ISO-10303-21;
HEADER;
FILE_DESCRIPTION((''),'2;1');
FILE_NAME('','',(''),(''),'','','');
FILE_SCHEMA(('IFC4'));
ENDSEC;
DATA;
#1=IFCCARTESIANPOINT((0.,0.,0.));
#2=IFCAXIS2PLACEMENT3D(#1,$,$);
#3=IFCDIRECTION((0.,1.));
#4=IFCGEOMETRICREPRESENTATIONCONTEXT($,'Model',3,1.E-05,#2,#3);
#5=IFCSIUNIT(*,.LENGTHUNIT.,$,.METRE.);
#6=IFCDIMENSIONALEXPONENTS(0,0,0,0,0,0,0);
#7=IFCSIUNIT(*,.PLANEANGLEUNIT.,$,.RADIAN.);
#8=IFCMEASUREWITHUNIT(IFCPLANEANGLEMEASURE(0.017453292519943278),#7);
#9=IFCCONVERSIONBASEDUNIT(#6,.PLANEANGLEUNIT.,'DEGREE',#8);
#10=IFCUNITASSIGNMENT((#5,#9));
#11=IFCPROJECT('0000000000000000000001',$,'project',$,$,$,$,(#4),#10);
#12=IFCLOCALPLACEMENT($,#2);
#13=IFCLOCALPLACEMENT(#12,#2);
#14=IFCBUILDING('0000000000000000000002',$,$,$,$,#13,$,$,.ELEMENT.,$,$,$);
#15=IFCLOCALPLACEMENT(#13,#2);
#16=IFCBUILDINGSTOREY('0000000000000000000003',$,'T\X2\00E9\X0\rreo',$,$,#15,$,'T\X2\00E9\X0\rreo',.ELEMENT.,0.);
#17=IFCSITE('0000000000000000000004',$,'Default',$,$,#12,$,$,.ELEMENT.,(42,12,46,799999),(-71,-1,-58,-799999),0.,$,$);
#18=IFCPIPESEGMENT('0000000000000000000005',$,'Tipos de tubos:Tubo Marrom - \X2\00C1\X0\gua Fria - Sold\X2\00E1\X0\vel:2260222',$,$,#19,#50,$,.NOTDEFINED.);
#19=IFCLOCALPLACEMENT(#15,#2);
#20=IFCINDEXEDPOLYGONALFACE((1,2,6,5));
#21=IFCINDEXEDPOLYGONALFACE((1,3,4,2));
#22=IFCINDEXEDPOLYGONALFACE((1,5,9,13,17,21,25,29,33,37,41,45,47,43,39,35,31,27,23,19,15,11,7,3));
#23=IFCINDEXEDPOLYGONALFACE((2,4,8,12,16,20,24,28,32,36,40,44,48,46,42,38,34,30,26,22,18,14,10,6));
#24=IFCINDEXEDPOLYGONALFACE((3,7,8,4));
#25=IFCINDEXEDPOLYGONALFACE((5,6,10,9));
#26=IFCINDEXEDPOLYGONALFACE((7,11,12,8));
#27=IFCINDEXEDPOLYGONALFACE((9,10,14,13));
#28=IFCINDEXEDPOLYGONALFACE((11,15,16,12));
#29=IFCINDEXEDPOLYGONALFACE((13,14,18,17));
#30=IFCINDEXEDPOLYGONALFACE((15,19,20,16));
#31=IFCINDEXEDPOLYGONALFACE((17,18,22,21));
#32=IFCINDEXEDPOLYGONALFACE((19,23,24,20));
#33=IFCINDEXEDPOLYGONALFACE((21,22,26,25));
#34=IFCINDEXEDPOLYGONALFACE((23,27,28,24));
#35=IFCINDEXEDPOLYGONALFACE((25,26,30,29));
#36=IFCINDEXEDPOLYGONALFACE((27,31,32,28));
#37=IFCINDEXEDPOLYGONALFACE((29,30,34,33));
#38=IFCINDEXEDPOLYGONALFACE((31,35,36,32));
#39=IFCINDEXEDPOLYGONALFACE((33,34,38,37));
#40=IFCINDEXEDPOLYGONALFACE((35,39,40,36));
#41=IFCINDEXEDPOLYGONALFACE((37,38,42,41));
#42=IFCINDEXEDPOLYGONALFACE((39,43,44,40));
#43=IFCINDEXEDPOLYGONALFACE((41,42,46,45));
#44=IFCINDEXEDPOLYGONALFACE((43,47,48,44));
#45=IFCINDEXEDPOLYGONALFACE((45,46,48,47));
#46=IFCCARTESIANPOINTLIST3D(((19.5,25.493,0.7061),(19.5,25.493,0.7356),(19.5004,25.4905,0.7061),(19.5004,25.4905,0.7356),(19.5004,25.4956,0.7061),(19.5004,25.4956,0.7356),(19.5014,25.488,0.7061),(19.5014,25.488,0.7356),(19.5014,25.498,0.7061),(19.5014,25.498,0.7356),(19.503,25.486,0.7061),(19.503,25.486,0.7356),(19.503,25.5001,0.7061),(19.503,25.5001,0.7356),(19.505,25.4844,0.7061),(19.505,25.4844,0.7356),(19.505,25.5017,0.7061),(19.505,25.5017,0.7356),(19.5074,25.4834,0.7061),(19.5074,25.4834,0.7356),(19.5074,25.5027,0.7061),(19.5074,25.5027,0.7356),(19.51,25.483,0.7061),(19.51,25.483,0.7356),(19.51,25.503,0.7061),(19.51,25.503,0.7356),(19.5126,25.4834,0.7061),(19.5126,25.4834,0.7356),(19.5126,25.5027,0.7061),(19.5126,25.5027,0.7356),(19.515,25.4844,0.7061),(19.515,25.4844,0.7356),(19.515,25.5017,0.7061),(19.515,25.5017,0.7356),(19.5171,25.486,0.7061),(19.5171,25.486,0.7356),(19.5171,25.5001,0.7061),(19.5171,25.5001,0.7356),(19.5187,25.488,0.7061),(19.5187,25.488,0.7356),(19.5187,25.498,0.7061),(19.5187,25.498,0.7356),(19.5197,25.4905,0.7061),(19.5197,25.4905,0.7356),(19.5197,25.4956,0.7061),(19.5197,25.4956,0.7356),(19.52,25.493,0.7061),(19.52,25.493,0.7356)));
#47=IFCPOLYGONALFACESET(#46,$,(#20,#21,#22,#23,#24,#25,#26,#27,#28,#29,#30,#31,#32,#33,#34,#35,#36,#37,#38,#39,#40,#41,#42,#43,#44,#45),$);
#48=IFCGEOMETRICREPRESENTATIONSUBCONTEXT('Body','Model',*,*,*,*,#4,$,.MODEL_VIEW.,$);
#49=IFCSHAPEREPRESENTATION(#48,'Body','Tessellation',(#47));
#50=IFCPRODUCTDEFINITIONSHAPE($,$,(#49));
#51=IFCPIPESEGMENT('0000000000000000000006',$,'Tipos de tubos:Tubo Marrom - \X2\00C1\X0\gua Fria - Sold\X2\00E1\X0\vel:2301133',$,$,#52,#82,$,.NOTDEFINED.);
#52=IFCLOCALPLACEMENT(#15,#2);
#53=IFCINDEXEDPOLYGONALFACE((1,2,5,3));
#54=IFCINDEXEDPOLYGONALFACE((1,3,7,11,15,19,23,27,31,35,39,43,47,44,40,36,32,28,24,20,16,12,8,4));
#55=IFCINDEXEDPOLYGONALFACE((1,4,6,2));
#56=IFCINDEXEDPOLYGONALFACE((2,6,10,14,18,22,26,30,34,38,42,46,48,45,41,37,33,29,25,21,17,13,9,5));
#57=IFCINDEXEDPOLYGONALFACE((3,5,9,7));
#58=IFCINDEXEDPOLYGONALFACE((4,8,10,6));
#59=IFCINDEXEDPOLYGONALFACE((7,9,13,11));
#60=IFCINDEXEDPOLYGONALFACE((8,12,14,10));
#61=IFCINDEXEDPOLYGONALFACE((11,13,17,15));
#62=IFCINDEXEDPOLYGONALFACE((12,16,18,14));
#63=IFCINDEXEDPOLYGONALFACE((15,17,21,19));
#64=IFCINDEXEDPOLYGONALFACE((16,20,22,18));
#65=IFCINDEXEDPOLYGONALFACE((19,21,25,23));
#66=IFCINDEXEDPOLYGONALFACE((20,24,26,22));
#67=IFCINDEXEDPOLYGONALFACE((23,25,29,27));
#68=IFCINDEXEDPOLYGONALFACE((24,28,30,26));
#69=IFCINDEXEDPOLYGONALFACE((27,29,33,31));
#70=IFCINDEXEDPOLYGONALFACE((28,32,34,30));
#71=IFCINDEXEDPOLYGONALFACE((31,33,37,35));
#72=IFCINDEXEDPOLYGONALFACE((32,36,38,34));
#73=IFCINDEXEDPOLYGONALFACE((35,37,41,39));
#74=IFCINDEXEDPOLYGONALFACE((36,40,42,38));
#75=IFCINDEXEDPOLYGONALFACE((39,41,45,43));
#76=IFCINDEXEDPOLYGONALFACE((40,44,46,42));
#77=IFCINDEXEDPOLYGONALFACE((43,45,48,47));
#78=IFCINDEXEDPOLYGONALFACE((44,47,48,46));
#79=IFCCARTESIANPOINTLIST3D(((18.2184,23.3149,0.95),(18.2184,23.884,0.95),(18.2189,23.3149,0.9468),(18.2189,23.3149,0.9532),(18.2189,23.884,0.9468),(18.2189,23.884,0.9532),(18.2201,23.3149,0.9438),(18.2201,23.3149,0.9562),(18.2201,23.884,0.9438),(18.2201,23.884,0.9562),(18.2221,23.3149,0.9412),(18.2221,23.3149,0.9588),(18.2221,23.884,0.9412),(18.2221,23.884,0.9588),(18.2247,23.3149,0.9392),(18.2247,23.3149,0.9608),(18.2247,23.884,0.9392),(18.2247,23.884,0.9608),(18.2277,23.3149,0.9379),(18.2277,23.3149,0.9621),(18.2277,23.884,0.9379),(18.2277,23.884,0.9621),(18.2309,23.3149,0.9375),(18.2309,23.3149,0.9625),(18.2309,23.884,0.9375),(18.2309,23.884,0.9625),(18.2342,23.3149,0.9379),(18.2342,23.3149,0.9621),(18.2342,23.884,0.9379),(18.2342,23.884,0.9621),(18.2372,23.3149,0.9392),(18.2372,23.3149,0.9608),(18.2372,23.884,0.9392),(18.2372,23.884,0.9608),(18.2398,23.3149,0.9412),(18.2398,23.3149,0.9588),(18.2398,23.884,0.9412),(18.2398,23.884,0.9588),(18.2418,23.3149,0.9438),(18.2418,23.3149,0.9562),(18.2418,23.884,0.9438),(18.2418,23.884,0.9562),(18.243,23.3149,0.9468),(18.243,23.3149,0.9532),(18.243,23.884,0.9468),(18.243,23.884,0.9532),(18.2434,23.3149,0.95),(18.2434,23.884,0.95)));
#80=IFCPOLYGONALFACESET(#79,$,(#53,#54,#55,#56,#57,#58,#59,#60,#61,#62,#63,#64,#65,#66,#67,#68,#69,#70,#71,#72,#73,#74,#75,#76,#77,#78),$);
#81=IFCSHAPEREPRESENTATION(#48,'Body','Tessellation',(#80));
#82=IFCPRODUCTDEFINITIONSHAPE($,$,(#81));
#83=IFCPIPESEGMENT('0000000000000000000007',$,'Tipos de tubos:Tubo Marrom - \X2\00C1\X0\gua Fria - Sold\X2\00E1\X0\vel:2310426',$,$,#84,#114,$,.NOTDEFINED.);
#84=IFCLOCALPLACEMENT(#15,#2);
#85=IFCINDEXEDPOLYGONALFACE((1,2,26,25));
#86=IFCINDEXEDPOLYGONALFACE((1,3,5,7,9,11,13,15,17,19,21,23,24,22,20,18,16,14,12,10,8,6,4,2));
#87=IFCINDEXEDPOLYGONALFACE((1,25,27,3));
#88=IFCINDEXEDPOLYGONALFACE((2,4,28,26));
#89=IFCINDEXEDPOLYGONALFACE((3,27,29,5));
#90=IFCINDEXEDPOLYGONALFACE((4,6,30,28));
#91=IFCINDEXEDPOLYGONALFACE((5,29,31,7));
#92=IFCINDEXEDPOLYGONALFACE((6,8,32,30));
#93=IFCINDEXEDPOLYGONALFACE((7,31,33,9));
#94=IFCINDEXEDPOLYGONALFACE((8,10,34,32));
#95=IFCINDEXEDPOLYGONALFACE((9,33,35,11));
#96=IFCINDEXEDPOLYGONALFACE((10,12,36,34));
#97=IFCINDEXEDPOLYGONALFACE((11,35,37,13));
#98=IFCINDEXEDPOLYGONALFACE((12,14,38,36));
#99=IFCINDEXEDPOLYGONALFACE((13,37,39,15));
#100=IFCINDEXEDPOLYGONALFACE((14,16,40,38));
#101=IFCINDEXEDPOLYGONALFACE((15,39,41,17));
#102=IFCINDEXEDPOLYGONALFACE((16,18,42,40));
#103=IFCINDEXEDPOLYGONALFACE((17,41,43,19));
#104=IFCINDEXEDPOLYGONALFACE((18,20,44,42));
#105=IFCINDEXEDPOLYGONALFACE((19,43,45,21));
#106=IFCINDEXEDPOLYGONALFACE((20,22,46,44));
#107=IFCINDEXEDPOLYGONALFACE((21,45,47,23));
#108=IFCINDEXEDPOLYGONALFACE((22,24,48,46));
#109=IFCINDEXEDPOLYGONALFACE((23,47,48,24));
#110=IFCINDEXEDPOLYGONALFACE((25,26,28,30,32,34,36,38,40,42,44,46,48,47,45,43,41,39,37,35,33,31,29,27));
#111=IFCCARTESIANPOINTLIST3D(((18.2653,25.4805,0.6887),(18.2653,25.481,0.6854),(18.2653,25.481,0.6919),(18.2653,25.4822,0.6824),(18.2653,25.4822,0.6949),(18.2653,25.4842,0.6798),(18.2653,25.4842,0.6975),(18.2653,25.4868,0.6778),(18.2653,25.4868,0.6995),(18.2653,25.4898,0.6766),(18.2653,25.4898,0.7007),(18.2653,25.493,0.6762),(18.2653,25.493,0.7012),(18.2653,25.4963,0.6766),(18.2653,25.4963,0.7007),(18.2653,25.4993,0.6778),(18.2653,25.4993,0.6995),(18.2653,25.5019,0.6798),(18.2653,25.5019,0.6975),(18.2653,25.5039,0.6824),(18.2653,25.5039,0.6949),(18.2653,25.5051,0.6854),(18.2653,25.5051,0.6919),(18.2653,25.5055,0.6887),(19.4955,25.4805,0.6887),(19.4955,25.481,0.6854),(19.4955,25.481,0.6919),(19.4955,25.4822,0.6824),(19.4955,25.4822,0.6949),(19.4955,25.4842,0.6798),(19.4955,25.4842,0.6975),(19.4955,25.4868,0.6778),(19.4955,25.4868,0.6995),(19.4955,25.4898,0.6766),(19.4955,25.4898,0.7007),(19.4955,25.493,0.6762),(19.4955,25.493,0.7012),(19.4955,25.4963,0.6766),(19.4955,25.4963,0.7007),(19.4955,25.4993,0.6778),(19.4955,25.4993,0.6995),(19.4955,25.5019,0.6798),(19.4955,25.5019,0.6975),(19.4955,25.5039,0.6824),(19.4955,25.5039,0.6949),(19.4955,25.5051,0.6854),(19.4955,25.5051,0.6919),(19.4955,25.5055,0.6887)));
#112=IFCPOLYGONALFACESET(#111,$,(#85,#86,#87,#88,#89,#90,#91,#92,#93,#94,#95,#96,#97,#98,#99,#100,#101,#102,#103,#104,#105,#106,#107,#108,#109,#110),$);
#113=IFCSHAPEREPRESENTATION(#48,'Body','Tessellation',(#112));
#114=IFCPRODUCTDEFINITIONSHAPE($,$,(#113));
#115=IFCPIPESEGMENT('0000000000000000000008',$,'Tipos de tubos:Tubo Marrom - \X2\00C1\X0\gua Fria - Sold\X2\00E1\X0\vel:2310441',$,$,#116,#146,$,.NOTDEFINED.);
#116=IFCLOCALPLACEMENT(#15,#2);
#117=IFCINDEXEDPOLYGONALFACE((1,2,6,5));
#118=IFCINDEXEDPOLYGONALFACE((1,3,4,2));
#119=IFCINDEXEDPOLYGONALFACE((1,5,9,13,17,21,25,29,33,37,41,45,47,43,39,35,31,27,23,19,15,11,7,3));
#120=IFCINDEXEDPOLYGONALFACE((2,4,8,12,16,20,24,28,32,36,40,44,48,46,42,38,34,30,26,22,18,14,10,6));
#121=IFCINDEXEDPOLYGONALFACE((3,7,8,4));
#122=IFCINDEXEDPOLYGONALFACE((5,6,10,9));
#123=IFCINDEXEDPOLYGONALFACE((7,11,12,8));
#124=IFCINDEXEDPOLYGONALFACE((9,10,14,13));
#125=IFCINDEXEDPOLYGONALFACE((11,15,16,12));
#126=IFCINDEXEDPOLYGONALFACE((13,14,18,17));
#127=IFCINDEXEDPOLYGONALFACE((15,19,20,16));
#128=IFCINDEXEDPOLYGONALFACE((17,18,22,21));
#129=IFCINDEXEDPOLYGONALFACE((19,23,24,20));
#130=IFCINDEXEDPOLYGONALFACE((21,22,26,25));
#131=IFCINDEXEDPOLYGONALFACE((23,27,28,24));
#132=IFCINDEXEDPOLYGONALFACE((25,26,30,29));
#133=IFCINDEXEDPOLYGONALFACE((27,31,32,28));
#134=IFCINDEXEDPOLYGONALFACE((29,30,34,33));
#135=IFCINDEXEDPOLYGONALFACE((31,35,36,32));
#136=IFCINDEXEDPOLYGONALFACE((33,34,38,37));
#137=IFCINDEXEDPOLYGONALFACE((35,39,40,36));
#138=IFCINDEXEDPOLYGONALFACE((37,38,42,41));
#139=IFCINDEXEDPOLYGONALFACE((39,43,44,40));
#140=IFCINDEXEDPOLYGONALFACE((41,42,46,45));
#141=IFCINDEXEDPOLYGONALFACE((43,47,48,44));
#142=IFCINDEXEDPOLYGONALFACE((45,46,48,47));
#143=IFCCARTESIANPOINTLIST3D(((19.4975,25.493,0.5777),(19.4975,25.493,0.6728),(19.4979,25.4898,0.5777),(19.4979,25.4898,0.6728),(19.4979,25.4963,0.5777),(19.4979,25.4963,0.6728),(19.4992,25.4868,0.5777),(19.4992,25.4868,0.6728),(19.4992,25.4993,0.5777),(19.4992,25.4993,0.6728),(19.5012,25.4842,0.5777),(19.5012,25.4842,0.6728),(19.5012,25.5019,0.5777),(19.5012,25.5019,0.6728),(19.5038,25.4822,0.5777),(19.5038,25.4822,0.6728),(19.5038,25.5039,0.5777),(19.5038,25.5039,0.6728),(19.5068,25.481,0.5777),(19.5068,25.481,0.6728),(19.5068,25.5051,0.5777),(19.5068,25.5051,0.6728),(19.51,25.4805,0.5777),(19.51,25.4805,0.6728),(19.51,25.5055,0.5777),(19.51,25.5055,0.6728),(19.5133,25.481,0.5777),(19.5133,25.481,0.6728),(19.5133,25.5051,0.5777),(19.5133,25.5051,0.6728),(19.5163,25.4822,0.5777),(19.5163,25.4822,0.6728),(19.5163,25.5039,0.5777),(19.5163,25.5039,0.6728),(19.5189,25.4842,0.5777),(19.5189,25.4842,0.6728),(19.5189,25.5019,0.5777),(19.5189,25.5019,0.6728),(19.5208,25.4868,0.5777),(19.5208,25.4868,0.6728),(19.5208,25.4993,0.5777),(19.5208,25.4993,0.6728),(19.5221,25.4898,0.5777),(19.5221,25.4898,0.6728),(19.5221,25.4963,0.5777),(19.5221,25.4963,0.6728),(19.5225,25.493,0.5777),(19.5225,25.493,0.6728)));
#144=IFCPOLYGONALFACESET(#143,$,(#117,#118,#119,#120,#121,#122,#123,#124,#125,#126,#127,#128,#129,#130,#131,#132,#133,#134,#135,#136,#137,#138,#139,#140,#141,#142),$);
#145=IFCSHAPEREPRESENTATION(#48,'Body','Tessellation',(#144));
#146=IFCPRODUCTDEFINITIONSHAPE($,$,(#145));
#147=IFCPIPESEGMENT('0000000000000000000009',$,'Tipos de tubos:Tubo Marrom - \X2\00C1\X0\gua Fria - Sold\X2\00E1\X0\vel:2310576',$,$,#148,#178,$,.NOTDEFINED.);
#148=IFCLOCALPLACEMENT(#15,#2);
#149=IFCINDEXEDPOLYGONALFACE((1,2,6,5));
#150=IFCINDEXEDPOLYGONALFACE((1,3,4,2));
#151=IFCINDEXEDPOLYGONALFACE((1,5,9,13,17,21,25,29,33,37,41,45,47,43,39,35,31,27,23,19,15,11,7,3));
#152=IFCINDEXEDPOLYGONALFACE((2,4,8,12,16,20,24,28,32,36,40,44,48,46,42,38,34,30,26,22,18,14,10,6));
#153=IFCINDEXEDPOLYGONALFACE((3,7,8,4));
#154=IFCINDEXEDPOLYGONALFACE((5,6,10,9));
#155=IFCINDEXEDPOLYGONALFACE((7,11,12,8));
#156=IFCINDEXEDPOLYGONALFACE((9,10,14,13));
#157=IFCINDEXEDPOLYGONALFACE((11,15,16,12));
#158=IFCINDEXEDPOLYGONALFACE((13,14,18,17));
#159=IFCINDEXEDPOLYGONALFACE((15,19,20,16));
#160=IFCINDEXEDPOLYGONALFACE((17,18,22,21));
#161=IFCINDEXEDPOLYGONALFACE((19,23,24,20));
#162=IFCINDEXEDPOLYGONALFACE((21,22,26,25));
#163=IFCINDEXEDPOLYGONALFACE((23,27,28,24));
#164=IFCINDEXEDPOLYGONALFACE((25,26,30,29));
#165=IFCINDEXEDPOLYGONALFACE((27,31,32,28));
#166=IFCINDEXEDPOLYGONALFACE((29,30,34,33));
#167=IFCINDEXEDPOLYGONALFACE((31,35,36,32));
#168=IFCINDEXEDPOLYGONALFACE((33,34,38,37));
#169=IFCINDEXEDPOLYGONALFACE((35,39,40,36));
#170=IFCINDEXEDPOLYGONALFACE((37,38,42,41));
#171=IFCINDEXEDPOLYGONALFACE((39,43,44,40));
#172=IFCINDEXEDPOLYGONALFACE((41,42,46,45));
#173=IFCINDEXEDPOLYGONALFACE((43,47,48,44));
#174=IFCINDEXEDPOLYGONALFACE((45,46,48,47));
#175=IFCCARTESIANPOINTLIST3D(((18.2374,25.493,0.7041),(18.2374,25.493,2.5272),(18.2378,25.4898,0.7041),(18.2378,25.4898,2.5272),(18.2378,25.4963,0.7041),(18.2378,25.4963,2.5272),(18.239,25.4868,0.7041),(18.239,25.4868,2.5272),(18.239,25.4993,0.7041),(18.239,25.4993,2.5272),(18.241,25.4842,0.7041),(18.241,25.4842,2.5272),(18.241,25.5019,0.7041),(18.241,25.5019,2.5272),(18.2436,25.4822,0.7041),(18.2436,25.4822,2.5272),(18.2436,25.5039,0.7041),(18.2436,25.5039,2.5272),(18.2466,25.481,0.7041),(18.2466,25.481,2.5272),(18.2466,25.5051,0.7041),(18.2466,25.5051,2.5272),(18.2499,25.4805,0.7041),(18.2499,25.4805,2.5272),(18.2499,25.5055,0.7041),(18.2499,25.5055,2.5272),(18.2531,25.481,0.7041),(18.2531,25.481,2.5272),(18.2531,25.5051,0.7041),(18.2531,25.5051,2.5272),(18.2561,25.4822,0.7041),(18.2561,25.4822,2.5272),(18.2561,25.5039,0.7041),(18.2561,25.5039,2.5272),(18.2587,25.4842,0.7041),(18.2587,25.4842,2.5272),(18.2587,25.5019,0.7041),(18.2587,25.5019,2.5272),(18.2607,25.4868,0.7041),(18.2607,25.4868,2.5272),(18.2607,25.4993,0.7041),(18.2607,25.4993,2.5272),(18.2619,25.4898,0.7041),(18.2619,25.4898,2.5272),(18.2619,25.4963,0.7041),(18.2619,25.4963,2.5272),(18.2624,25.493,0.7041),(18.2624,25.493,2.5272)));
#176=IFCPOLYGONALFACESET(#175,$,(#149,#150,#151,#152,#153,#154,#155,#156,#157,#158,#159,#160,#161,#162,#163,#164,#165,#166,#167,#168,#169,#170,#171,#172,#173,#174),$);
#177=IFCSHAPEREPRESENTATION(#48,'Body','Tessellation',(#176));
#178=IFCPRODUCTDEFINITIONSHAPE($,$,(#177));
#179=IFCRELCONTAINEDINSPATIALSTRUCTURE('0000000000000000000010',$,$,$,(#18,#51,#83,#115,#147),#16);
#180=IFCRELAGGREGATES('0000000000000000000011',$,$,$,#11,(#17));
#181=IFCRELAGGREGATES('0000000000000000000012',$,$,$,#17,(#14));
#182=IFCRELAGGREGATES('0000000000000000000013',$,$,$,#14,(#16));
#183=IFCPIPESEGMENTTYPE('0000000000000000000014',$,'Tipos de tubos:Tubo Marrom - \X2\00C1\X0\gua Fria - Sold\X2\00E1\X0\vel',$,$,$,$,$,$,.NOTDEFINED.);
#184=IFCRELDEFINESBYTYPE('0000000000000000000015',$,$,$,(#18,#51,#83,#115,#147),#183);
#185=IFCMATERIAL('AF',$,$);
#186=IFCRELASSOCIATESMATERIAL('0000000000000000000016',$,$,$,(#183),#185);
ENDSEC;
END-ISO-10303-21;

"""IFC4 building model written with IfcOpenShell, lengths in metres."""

from ifc_helpers import new_model, entity, si_unit, converted_unit, direction, frame, origin, place, context, subcontext, project, spatial, arc, indexed_curve, outline, extrude, material, type_object, element, save


model = new_model("IFC4")

# Units and contexts
model_context = context("Model", 3, precision=1e-05, world=origin(), true_north=direction((0.0, 1.0)))
body_context = subcontext(model_context, "Body", "Model", "MODEL_VIEW")
ifc_project = project(units=[si_unit("LENGTHUNIT", "METRE"), converted_unit("PLANEANGLEUNIT", "DEGREE", entity("IfcPlaneAngleMeasure", 0.017453292519943278), si_unit("PLANEANGLEUNIT", "RADIAN"), dimensions=[0, 0, 0, 0, 0, 0, 0])], contexts=[model_context])

# Site, building, storey
site_placement = place(None, origin())
site = spatial("IfcSite", under=ifc_project, at=site_placement, Name="Default", CompositionType="ELEMENT", RefLatitude=(42, 12, 46, 799999), RefLongitude=(-71, -1, -58, -799999), RefElevation=0.0)
building_placement = place(site_placement, origin())
building = spatial("IfcBuilding", under=site, at=building_placement, CompositionType="ELEMENT")
storey_placement = place(building_placement, origin())
storey = spatial("IfcBuildingStorey", under=building, at=storey_placement, Name="Térreo", LongName="Térreo", CompositionType="ELEMENT", Elevation=0.0)

# Pipe segments
ifc_material_1 = material(Name="AF")
pipe_segment_type_1 = type_object("IfcPipeSegmentType", Name="Tipos de tubos:Tubo Marrom - Água Fria - Soldável", PredefinedType="NOTDEFINED", material=ifc_material_1)
pipe_segment_1_placement = place(storey_placement, origin())
element("IfcPipeSegment", 1, at=pipe_segment_1_placement, inside=storey, type_object=pipe_segment_type_1, Name="Tipos de tubos:Tubo Marrom - Água Fria - Soldável:2260222", PredefinedType="NOTDEFINED", context=body_context, shape_type="SweptSolid", body=[
    extrude(outline(indexed_curve([(0.01, 0.0), (0.0071, 0.0071), (0.0, 0.01), (-0.0071, 0.0071), (-0.01, 0.0), (-0.0071, -0.0071), (0.0, -0.01), (0.0071, -0.0071)], segments=[arc(1, 2, 3), arc(3, 4, 5), arc(5, 6, 7), arc(7, 8, 1)], self_intersect=False)), frame((19.51, 25.493, 0.7061), z_axis=(0.0, 0.0, 1.0), x_axis=(-1.0, 0.0, 0.0)), (0.0, 0.0, 1.0), 0.0295),
])
pipe_segment_2_placement = place(storey_placement, origin())
element("IfcPipeSegment", 2, at=pipe_segment_2_placement, inside=storey, type_object=pipe_segment_type_1, Name="Tipos de tubos:Tubo Marrom - Água Fria - Soldável:2301133", PredefinedType="NOTDEFINED", context=body_context, shape_type="SweptSolid", body=[
    extrude(outline(indexed_curve([(0.0125, 0.0), (0.0088, 0.0088), (0.0, 0.0125), (-0.0088, 0.0088), (-0.0125, 0.0), (-0.0088, -0.0088), (0.0, -0.0125), (0.0088, -0.0088)], segments=[arc(1, 2, 3), arc(3, 4, 5), arc(5, 6, 7), arc(7, 8, 1)], self_intersect=False)), frame((18.2309, 23.3149, 0.95), z_axis=(0.0, 1.0, 0.0), x_axis=(1.0, 0.0, 0.0)), (0.0, 0.0, 1.0), 0.5691),
])
pipe_segment_3_placement = place(storey_placement, origin())
element("IfcPipeSegment", 3, at=pipe_segment_3_placement, inside=storey, type_object=pipe_segment_type_1, Name="Tipos de tubos:Tubo Marrom - Água Fria - Soldável:2310426", PredefinedType="NOTDEFINED", context=body_context, shape_type="SweptSolid", body=[
    extrude(outline(indexed_curve([(0.0125, 0.0), (0.0088, 0.0088), (0.0, 0.0125), (-0.0088, 0.0088), (-0.0125, 0.0), (-0.0088, -0.0088), (0.0, -0.0125), (0.0088, -0.0088)], segments=[arc(1, 2, 3), arc(3, 4, 5), arc(5, 6, 7), arc(7, 8, 1)], self_intersect=False)), frame((18.2653, 25.493, 0.6887), z_axis=(1.0, 0.0, 0.0), x_axis=(0.0, 1.0, 0.0)), (0.0, 0.0, 1.0), 1.2302),
])
pipe_segment_4_placement = place(storey_placement, origin())
element("IfcPipeSegment", 4, at=pipe_segment_4_placement, inside=storey, type_object=pipe_segment_type_1, Name="Tipos de tubos:Tubo Marrom - Água Fria - Soldável:2310441", PredefinedType="NOTDEFINED", context=body_context, shape_type="SweptSolid", body=[
    extrude(outline(indexed_curve([(0.0125, 0.0), (0.0088, 0.0088), (0.0, 0.0125), (-0.0088, 0.0088), (-0.0125, 0.0), (-0.0088, -0.0088), (0.0, -0.0125), (0.0088, -0.0088)], segments=[arc(1, 2, 3), arc(3, 4, 5), arc(5, 6, 7), arc(7, 8, 1)], self_intersect=False)), frame((19.51, 25.493, 0.5777), z_axis=(0.0, 0.0, 1.0), x_axis=(-1.0, 0.0, 0.0)), (0.0, 0.0, 1.0), 0.0951),
])
pipe_segment_5_placement = place(storey_placement, origin())
element("IfcPipeSegment", 5, at=pipe_segment_5_placement, inside=storey, type_object=pipe_segment_type_1, Name="Tipos de tubos:Tubo Marrom - Água Fria - Soldável:2310576", PredefinedType="NOTDEFINED", context=body_context, shape_type="SweptSolid", body=[
    extrude(outline(indexed_curve([(0.0125, 0.0), (0.0088, 0.0088), (0.0, 0.0125), (-0.0088, 0.0088), (-0.0125, 0.0), (-0.0088, -0.0088), (0.0, -0.0125), (0.0088, -0.0088)], segments=[arc(1, 2, 3), arc(3, 4, 5), arc(5, 6, 7), arc(7, 8, 1)], self_intersect=False)), frame((18.2499, 25.493, 0.7041), z_axis=(0.0, 0.0, 1.0), x_axis=(-1.0, 0.0, 0.0)), (0.0, 0.0, 1.0), 1.8232),
])

save(model, "model.ifc")
